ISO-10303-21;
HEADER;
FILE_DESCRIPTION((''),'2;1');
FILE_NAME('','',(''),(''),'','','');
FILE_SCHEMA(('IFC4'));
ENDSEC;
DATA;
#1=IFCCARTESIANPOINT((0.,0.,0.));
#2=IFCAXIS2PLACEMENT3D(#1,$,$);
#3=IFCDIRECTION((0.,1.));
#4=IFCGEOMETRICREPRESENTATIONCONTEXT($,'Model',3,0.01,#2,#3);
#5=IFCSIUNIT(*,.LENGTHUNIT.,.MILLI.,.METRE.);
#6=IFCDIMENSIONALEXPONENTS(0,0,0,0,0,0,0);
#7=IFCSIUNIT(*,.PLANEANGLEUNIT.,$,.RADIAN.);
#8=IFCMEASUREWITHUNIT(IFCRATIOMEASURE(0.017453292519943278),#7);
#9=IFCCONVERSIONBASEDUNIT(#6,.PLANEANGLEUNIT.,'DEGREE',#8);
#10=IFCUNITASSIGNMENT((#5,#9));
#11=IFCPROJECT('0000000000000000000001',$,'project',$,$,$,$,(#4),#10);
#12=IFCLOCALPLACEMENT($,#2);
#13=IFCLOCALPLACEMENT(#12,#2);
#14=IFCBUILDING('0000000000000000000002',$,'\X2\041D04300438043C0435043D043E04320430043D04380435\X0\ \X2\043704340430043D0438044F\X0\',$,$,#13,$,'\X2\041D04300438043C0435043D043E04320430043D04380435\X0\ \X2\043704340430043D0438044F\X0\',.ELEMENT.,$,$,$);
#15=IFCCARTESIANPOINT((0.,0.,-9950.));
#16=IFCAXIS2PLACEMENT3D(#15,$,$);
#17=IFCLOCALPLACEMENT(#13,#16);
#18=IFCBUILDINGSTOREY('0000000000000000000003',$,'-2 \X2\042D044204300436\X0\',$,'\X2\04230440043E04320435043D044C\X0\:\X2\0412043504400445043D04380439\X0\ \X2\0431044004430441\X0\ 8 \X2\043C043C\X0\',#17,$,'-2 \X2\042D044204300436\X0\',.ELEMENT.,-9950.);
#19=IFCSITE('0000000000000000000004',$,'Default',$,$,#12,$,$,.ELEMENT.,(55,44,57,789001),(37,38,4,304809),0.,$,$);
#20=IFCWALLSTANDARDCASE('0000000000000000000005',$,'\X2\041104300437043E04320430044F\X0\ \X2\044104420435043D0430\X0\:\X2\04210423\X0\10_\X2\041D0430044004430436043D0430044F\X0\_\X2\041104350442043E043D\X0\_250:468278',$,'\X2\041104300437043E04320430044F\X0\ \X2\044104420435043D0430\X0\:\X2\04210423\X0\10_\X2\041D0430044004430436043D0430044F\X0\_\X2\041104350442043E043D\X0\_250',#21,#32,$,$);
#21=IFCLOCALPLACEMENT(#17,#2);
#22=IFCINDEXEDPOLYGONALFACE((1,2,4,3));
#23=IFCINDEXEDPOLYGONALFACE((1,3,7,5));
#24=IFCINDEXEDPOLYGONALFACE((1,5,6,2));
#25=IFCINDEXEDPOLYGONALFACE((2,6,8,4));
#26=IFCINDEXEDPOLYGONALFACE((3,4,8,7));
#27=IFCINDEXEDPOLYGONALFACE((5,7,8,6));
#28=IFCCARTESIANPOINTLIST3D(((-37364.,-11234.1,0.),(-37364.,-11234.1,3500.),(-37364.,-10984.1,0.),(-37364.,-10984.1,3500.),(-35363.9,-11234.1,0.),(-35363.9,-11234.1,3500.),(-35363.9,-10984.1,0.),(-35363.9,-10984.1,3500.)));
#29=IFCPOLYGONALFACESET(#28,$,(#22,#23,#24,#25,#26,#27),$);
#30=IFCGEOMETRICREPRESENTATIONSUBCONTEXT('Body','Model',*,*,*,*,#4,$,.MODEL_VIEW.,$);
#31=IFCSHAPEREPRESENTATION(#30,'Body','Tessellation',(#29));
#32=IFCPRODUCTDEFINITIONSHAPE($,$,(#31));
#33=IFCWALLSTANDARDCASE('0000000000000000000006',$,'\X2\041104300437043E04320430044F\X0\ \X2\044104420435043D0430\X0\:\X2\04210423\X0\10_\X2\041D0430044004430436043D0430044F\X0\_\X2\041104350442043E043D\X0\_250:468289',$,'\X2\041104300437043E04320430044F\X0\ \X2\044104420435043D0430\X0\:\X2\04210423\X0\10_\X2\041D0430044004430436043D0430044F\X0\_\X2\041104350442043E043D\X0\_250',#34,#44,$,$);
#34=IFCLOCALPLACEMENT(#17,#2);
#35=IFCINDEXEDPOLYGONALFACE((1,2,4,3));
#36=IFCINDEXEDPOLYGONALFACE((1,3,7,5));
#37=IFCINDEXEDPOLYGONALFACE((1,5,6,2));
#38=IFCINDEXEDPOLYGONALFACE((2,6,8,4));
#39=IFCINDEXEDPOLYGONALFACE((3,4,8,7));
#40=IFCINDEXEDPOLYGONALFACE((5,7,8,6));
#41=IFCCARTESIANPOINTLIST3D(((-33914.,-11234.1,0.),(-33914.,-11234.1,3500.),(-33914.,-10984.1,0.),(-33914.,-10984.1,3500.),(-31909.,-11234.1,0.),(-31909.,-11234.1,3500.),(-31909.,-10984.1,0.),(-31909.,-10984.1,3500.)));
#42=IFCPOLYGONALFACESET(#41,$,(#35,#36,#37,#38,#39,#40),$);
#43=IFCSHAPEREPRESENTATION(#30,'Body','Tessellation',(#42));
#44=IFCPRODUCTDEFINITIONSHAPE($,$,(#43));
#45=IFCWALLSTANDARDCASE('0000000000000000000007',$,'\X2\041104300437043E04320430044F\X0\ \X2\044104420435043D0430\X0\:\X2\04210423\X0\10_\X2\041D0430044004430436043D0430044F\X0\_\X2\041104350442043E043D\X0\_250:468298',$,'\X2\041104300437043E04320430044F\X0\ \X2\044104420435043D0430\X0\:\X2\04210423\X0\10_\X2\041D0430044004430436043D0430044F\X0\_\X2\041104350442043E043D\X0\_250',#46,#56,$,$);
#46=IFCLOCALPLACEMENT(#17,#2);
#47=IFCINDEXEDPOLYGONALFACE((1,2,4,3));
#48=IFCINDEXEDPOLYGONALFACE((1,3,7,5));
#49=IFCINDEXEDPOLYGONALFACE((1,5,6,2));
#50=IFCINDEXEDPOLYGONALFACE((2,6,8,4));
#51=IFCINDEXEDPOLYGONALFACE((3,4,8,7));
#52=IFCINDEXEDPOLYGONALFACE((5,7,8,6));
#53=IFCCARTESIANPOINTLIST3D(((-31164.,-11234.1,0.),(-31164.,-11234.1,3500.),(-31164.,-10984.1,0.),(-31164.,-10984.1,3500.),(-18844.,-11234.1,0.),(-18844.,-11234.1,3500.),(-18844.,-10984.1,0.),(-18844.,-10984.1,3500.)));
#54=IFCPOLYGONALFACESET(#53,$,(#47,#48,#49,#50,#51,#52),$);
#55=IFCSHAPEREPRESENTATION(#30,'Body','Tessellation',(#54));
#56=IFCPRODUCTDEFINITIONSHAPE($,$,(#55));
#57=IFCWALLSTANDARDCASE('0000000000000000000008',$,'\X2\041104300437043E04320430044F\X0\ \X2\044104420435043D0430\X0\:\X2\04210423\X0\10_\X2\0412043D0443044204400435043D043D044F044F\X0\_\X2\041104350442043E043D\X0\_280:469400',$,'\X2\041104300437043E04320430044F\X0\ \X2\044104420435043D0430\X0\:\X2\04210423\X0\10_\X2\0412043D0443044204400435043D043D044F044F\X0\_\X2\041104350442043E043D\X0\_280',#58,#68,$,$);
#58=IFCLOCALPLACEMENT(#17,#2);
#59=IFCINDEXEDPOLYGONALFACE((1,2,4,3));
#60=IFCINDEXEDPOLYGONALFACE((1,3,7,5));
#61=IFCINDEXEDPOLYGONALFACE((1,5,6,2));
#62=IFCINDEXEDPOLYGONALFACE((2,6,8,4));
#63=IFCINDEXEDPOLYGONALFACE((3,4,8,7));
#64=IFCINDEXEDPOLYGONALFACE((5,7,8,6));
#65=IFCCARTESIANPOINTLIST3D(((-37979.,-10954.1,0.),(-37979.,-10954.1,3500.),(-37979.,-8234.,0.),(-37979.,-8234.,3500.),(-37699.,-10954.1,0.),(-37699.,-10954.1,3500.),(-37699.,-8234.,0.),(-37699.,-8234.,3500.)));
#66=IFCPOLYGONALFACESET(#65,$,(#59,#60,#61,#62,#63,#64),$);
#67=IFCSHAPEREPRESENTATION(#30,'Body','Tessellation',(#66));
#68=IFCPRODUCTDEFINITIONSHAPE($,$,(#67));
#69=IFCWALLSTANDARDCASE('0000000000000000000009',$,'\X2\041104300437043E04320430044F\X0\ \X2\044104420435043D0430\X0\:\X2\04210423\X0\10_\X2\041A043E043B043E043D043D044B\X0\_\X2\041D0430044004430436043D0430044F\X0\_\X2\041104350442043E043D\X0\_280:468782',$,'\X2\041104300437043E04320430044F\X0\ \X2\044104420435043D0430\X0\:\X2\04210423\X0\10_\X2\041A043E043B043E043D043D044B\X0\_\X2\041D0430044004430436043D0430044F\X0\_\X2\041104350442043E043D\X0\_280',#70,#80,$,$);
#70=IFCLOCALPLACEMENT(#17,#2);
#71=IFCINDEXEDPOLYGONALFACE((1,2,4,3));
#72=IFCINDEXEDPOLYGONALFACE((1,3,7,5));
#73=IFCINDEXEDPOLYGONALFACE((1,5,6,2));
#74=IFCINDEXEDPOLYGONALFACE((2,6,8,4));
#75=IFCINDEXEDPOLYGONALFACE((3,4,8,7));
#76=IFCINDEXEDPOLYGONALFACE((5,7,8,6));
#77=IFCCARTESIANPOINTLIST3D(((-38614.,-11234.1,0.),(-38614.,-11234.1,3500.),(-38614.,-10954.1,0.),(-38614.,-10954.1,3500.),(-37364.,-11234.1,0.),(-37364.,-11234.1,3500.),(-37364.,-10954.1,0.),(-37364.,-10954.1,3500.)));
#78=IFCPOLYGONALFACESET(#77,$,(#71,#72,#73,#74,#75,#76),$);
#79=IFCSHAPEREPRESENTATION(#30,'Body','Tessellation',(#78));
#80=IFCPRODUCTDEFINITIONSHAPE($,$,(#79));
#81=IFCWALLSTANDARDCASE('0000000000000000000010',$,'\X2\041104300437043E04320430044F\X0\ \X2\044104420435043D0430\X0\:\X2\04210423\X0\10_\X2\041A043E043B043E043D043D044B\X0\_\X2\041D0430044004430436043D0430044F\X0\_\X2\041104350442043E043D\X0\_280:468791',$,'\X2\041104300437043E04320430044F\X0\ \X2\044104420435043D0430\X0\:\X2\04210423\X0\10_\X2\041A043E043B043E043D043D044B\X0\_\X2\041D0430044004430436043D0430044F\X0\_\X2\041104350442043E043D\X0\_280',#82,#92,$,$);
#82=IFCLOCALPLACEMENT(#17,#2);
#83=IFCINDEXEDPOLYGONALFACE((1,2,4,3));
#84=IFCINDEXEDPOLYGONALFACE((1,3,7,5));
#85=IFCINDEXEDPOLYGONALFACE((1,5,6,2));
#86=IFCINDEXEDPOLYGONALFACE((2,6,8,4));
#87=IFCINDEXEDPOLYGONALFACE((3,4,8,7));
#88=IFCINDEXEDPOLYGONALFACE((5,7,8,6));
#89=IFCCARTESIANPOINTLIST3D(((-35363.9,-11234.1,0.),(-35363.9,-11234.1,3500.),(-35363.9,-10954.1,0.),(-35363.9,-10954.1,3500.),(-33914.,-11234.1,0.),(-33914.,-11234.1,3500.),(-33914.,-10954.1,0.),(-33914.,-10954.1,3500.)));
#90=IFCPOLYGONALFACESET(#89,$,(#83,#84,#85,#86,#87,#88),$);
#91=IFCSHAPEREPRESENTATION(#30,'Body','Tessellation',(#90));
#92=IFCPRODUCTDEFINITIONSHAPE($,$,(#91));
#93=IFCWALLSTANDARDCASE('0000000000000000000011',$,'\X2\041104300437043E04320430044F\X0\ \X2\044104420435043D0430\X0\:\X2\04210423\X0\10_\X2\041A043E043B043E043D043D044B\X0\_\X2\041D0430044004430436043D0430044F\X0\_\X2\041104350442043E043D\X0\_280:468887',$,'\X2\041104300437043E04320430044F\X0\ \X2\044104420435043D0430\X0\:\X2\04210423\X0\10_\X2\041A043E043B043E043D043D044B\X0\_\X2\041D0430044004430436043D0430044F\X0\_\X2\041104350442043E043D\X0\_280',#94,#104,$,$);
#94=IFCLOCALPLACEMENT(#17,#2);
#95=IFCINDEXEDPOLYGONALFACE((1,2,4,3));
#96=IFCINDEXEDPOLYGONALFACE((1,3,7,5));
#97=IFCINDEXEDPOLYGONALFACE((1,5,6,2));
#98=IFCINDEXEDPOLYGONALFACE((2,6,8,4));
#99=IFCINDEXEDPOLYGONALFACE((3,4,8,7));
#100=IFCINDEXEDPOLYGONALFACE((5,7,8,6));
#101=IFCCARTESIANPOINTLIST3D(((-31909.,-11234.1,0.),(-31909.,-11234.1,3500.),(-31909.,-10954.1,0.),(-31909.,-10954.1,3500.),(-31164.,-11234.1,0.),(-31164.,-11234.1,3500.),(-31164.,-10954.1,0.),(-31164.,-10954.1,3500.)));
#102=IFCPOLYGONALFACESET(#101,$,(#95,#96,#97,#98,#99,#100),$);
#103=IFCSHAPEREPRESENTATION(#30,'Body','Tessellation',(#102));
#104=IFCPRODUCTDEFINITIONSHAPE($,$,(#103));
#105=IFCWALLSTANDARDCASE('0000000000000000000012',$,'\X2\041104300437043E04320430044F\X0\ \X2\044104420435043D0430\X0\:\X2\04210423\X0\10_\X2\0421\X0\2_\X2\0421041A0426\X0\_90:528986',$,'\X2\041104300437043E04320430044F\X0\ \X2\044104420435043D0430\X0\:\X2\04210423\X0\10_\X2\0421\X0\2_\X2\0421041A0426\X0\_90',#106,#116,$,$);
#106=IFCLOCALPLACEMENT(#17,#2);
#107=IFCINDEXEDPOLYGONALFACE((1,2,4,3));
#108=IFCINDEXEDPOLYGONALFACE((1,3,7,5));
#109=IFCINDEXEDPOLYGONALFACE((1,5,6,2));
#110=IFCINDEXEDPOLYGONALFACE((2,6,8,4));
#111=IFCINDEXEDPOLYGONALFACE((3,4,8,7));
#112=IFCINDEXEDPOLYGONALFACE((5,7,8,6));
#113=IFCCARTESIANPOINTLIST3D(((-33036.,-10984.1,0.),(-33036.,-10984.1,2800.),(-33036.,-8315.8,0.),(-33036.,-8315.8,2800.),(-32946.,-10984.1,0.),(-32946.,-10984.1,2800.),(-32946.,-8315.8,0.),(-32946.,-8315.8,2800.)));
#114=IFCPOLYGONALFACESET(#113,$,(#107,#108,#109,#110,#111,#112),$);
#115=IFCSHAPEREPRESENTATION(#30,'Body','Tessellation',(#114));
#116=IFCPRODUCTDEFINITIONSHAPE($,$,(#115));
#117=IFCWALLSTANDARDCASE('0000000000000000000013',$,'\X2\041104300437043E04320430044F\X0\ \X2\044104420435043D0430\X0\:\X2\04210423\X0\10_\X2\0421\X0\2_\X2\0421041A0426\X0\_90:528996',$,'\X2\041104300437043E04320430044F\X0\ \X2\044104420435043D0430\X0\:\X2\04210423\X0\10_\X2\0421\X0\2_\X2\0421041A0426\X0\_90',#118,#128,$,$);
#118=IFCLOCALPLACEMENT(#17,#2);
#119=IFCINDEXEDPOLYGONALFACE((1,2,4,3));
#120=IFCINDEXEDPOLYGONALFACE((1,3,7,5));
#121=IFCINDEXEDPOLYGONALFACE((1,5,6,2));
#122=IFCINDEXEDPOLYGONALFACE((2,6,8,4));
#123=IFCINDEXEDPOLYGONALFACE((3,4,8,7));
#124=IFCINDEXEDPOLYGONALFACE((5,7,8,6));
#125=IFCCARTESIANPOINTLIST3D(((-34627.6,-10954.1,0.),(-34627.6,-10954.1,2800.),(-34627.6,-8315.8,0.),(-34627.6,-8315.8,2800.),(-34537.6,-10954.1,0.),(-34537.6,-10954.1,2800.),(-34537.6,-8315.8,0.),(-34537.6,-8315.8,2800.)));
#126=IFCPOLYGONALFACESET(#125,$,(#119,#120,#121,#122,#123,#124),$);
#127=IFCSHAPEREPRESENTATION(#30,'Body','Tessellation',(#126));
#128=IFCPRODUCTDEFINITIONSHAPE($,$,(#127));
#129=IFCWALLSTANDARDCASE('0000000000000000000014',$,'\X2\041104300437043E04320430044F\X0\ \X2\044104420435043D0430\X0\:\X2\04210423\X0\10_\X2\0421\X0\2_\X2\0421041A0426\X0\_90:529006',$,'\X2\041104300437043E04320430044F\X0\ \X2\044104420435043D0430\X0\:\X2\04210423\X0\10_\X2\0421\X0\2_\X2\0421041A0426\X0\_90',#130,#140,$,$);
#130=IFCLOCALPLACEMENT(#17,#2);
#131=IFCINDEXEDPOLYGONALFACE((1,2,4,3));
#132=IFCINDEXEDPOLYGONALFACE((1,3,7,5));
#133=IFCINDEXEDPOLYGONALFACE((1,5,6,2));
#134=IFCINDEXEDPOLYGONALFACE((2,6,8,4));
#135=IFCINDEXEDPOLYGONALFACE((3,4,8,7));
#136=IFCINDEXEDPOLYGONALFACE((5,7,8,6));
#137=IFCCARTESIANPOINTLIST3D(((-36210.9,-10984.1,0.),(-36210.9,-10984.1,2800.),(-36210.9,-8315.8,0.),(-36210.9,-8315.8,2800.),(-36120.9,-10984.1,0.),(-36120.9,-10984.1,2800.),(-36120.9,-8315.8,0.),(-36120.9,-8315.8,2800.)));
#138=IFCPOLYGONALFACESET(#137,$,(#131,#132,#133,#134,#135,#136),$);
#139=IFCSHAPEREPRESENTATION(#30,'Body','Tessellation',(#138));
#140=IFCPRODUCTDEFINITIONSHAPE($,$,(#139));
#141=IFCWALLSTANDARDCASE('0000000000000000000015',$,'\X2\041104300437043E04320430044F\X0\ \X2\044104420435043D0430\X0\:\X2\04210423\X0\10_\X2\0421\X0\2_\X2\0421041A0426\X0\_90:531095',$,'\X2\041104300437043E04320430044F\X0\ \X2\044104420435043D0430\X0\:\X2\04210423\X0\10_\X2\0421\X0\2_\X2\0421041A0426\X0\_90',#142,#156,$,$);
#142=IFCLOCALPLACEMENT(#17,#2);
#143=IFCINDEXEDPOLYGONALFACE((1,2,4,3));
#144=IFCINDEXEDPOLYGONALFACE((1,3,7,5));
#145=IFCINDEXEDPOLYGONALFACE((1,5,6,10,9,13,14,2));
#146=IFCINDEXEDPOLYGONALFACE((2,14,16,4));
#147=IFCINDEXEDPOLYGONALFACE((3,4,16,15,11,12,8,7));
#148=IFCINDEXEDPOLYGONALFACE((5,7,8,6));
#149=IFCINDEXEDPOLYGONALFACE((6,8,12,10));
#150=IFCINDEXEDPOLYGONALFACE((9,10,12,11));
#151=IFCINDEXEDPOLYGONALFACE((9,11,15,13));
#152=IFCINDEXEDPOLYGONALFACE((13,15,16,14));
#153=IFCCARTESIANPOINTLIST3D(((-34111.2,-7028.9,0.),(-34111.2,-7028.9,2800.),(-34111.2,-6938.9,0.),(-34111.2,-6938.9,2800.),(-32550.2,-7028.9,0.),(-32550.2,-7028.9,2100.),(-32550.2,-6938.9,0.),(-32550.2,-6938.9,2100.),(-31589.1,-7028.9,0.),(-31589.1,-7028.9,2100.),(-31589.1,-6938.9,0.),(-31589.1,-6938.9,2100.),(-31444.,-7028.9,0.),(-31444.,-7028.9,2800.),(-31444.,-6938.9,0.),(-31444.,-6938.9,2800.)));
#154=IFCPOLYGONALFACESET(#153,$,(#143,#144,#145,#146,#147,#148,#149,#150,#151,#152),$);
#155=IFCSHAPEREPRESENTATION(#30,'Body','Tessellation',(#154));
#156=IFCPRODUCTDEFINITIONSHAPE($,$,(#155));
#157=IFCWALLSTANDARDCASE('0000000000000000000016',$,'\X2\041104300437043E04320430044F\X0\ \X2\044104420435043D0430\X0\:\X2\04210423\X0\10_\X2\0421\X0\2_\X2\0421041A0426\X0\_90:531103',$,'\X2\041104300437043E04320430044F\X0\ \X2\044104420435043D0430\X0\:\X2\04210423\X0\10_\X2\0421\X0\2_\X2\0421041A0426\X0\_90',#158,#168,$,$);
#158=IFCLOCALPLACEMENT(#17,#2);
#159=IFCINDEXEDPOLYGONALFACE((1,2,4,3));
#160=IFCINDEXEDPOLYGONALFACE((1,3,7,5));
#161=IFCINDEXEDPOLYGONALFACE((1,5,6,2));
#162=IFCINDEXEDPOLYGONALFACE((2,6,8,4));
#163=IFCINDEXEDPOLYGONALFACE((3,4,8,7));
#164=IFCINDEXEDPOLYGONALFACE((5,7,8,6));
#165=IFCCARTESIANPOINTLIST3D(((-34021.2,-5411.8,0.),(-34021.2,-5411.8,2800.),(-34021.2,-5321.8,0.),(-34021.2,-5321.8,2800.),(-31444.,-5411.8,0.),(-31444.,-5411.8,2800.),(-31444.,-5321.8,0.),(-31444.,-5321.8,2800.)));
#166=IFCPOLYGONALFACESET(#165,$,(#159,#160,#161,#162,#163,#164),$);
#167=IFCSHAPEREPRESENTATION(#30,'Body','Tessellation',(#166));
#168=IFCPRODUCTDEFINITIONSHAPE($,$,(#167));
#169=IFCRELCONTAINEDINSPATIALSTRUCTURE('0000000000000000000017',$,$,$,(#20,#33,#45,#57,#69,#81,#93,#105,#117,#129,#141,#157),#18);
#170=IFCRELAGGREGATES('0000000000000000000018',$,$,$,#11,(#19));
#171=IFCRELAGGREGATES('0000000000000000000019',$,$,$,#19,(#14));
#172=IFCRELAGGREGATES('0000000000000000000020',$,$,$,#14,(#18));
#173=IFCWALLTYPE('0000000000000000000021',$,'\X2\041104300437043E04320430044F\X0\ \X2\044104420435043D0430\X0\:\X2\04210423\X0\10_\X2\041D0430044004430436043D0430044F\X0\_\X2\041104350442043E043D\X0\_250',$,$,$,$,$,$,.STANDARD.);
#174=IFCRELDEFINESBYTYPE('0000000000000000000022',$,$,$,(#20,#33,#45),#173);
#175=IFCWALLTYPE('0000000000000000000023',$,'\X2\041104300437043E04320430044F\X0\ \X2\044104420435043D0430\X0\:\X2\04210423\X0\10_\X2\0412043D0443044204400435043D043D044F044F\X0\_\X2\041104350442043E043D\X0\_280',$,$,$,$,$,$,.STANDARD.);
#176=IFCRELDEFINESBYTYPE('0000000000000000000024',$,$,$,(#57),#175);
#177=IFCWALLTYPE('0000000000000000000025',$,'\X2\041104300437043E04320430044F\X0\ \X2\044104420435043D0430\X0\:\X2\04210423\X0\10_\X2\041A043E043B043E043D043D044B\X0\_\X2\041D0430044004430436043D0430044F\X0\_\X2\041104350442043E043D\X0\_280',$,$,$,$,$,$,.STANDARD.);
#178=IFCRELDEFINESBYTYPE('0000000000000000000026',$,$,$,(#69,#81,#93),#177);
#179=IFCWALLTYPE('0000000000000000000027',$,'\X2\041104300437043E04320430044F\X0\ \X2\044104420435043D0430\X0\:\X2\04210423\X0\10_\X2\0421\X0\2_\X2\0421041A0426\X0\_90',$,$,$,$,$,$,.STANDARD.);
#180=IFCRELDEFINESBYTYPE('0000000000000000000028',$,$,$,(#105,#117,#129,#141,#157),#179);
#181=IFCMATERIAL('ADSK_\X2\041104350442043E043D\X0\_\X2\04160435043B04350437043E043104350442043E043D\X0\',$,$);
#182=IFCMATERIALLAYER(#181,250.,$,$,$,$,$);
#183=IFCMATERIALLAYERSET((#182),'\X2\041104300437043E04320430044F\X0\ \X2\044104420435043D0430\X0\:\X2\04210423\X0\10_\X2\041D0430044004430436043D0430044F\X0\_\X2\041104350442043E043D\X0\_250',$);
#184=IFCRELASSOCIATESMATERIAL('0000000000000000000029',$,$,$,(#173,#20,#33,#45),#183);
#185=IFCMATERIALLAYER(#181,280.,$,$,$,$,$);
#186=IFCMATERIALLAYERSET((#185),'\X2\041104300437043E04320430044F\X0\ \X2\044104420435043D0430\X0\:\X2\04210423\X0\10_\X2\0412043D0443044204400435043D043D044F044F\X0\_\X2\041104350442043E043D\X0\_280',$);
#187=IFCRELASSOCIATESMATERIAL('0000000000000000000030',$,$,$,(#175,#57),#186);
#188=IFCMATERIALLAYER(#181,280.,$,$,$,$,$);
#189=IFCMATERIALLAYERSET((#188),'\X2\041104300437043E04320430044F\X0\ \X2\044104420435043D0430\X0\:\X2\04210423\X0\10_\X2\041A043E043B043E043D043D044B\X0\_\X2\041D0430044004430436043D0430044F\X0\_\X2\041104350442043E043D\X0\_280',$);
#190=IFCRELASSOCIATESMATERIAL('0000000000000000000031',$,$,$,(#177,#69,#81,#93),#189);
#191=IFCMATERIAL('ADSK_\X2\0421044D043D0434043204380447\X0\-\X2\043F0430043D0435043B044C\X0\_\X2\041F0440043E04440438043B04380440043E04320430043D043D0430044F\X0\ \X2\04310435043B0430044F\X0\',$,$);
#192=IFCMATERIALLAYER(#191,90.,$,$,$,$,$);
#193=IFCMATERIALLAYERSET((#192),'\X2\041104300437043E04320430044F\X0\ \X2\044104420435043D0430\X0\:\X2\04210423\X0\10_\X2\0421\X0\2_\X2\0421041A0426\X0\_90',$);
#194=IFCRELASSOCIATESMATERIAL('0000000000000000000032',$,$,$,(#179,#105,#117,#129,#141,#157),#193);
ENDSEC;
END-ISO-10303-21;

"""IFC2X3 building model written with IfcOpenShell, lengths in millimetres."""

from ifc_helpers import new_model, entity, si_unit, converted_unit, direction, frame, frame_2d, origin, place, context, subcontext, project, spatial, rectangle, extrude, material, layer, layer_set, layer_usage, type_object, element, save


model = new_model("IFC2X3")

# Units and contexts
model_context = context("Model", 3, precision=0.01, world=origin(), true_north=direction((0.0, 1.0)))
body_context = subcontext(model_context, "Body", "Model", "MODEL_VIEW")
ifc_project = project(units=[si_unit("LENGTHUNIT", "METRE", prefix="MILLI"), converted_unit("PLANEANGLEUNIT", "DEGREE", entity("IfcRatioMeasure", 0.017453292519943278), si_unit("PLANEANGLEUNIT", "RADIAN"), dimensions=[0, 0, 0, 0, 0, 0, 0])], contexts=[model_context])

# Site, building, storey
site_placement = place(None, origin())
site = spatial("IfcSite", under=ifc_project, at=site_placement, Name="Default", CompositionType="ELEMENT", RefLatitude=(55, 44, 57, 789001), RefLongitude=(37, 38, 4, 304809), RefElevation=0.0)
building_placement = place(site_placement, origin())
building = spatial("IfcBuilding", under=site, at=building_placement, Name="Наименование здания", LongName="Наименование здания", CompositionType="ELEMENT")
storey_placement = place(building_placement, frame((0.0, 0.0, -9950.0)))
storey = spatial("IfcBuildingStorey", under=building, at=storey_placement, Name="-2 Этаж", ObjectType="Уровень:Верхний брус 8 мм", LongName="-2 Этаж", CompositionType="ELEMENT", Elevation=-9950.0)

# Shared definitions
ifc_material_1 = material(Name="ADSK_Бетон_Железобетон")

# Walls
ifc_layer_1 = layer(ifc_material_1, 250.0)
ifc_layer_set_1 = layer_set([ifc_layer_1], Name="Базовая стена:СУ10_Наружная_Бетон_250")
ifc_layer_usage_1 = layer_usage(ifc_layer_set_1, "AXIS2", "NEGATIVE", 125.0)
wall_type_1 = type_object("IfcWallType", Name="Базовая стена:СУ10_Наружная_Бетон_250", PredefinedType="STANDARD", material=ifc_layer_set_1)
wall_1_placement = place(storey_placement, frame((-37364.0, -11109.1, 0.0)))
element("IfcWallStandardCase", 1, at=wall_1_placement, inside=storey, type_object=wall_type_1, material=ifc_layer_usage_1, Name="Базовая стена:СУ10_Наружная_Бетон_250:468278", ObjectType="Базовая стена:СУ10_Наружная_Бетон_250", context=body_context, shape_type="SweptSolid", body=[
    extrude(rectangle(XDim=2000.1, YDim=250.0, at=frame_2d((1000.0, 0.0), x_axis=(-1.0, 0.0))), origin(), (0.0, 0.0, 1.0), 3500.0),
])
wall_2_placement = place(storey_placement, frame((-33914.0, -11109.1, 0.0)))
element("IfcWallStandardCase", 2, at=wall_2_placement, inside=storey, type_object=wall_type_1, material=ifc_layer_usage_1, Name="Базовая стена:СУ10_Наружная_Бетон_250:468289", ObjectType="Базовая стена:СУ10_Наружная_Бетон_250", context=body_context, shape_type="SweptSolid", body=[
    extrude(rectangle(XDim=2005.0, YDim=250.0, at=frame_2d((1002.5, 0.0), x_axis=(-1.0, 0.0))), origin(), (0.0, 0.0, 1.0), 3500.0),
])
wall_3_placement = place(storey_placement, frame((-31164.0, -11109.1, 0.0)))
element("IfcWallStandardCase", 3, at=wall_3_placement, inside=storey, type_object=wall_type_1, material=ifc_layer_usage_1, Name="Базовая стена:СУ10_Наружная_Бетон_250:468298", ObjectType="Базовая стена:СУ10_Наружная_Бетон_250", context=body_context, shape_type="SweptSolid", body=[
    extrude(rectangle(XDim=12320.0, YDim=250.0, at=frame_2d((6160.0, 0.0), x_axis=(-1.0, 0.0))), origin(), (0.0, 0.0, 1.0), 3500.0),
])
ifc_layer_2 = layer(ifc_material_1, 280.0)
ifc_layer_set_2 = layer_set([ifc_layer_2], Name="Базовая стена:СУ10_Внутренняя_Бетон_280")
ifc_layer_usage_2 = layer_usage(ifc_layer_set_2, "AXIS2", "NEGATIVE", 140.0)
wall_type_2 = type_object("IfcWallType", Name="Базовая стена:СУ10_Внутренняя_Бетон_280", PredefinedType="STANDARD", material=ifc_layer_set_2)
wall_4_placement = place(storey_placement, frame((-37839.0, -8234.0, 0.0), z_axis=(0.0, 0.0, 1.0), x_axis=(0.0, -1.0, 0.0)))
element("IfcWallStandardCase", 4, at=wall_4_placement, inside=storey, type_object=wall_type_2, material=ifc_layer_usage_2, Name="Базовая стена:СУ10_Внутренняя_Бетон_280:469400", ObjectType="Базовая стена:СУ10_Внутренняя_Бетон_280", context=body_context, shape_type="SweptSolid", body=[
    extrude(rectangle(XDim=2720.1, YDim=280.0, at=frame_2d((1360.0, 0.0), x_axis=(-1.0, 0.0))), origin(), (0.0, 0.0, 1.0), 3500.0),
])
ifc_layer_3 = layer(ifc_material_1, 280.0)
ifc_layer_set_3 = layer_set([ifc_layer_3], Name="Базовая стена:СУ10_Колонны_Наружная_Бетон_280")
ifc_layer_usage_3 = layer_usage(ifc_layer_set_3, "AXIS2", "NEGATIVE", 140.0)
wall_type_3 = type_object("IfcWallType", Name="Базовая стена:СУ10_Колонны_Наружная_Бетон_280", PredefinedType="STANDARD", material=ifc_layer_set_3)
wall_5_placement = place(storey_placement, frame((-38614.0, -11094.1, 0.0)))
element("IfcWallStandardCase", 5, at=wall_5_placement, inside=storey, type_object=wall_type_3, material=ifc_layer_usage_3, Name="Базовая стена:СУ10_Колонны_Наружная_Бетон_280:468782", ObjectType="Базовая стена:СУ10_Колонны_Наружная_Бетон_280", context=body_context, shape_type="SweptSolid", body=[
    extrude(rectangle(XDim=1250.0, YDim=280.0, at=frame_2d((625.0, 0.0), x_axis=(-1.0, 0.0))), origin(), (0.0, 0.0, 1.0), 3500.0),
])
wall_6_placement = place(storey_placement, frame((-35363.9, -11094.1, 0.0)))
element("IfcWallStandardCase", 6, at=wall_6_placement, inside=storey, type_object=wall_type_3, material=ifc_layer_usage_3, Name="Базовая стена:СУ10_Колонны_Наружная_Бетон_280:468791", ObjectType="Базовая стена:СУ10_Колонны_Наружная_Бетон_280", context=body_context, shape_type="SweptSolid", body=[
    extrude(rectangle(XDim=1450.0, YDim=280.0, at=frame_2d((725.0, 0.0), x_axis=(-1.0, 0.0))), origin(), (0.0, 0.0, 1.0), 3500.0),
])
wall_7_placement = place(storey_placement, frame((-31909.0, -11094.1, 0.0)))
element("IfcWallStandardCase", 7, at=wall_7_placement, inside=storey, type_object=wall_type_3, material=ifc_layer_usage_3, Name="Базовая стена:СУ10_Колонны_Наружная_Бетон_280:468887", ObjectType="Базовая стена:СУ10_Колонны_Наружная_Бетон_280", context=body_context, shape_type="SweptSolid", body=[
    extrude(rectangle(XDim=745.0, YDim=280.0, at=frame_2d((372.5, 0.0), x_axis=(-1.0, 0.0))), origin(), (0.0, 0.0, 1.0), 3500.0),
])
ifc_material_2 = material(Name="ADSK_Сэндвич-панель_Профилированная белая")
ifc_layer_4 = layer(ifc_material_2, 90.0)
ifc_layer_set_4 = layer_set([ifc_layer_4], Name="Базовая стена:СУ10_С2_СКЦ_90")
ifc_layer_usage_4 = layer_usage(ifc_layer_set_4, "AXIS2", "NEGATIVE", 45.0)
wall_type_4 = type_object("IfcWallType", Name="Базовая стена:СУ10_С2_СКЦ_90", PredefinedType="STANDARD", material=ifc_layer_set_4)
wall_8_placement = place(storey_placement, frame((-32991.0, -8315.8, 0.0), z_axis=(0.0, 0.0, 1.0), x_axis=(0.0, -1.0, 0.0)))
element("IfcWallStandardCase", 8, at=wall_8_placement, inside=storey, type_object=wall_type_4, material=ifc_layer_usage_4, Name="Базовая стена:СУ10_С2_СКЦ_90:528986", ObjectType="Базовая стена:СУ10_С2_СКЦ_90", context=body_context, shape_type="SweptSolid", body=[
    extrude(rectangle(XDim=2668.3, YDim=90.0, at=frame_2d((1334.1, 0.0), x_axis=(-1.0, 0.0))), origin(), (0.0, 0.0, 1.0), 2800.0),
])
wall_9_placement = place(storey_placement, frame((-34582.6, -8315.8, 0.0), z_axis=(0.0, 0.0, 1.0), x_axis=(0.0, -1.0, 0.0)))
element("IfcWallStandardCase", 9, at=wall_9_placement, inside=storey, type_object=wall_type_4, material=ifc_layer_usage_4, Name="Базовая стена:СУ10_С2_СКЦ_90:528996", ObjectType="Базовая стена:СУ10_С2_СКЦ_90", context=body_context, shape_type="SweptSolid", body=[
    extrude(rectangle(XDim=2638.3, YDim=90.0, at=frame_2d((1319.1, 0.0), x_axis=(-1.0, 0.0))), origin(), (0.0, 0.0, 1.0), 2800.0),
])
wall_10_placement = place(storey_placement, frame((-36165.9, -8315.8, 0.0), z_axis=(0.0, 0.0, 1.0), x_axis=(0.0, -1.0, 0.0)))
element("IfcWallStandardCase", 10, at=wall_10_placement, inside=storey, type_object=wall_type_4, material=ifc_layer_usage_4, Name="Базовая стена:СУ10_С2_СКЦ_90:529006", ObjectType="Базовая стена:СУ10_С2_СКЦ_90", context=body_context, shape_type="SweptSolid", body=[
    extrude(rectangle(XDim=2668.3, YDim=90.0, at=frame_2d((1334.1, 0.0), x_axis=(-1.0, 0.0))), origin(), (0.0, 0.0, 1.0), 2800.0),
])

# Wall, opening
wall_11_placement = place(storey_placement, frame((-31444.0, -6983.9, 0.0), z_axis=(0.0, 0.0, 1.0), x_axis=(-1.0, 0.0, 0.0)))
wall_11 = element("IfcWallStandardCase", 11, at=wall_11_placement, inside=storey, type_object=wall_type_4, material=ifc_layer_usage_4, Name="Базовая стена:СУ10_С2_СКЦ_90:531095", ObjectType="Базовая стена:СУ10_С2_СКЦ_90", context=body_context, shape_type="SweptSolid", body=[
    extrude(rectangle(XDim=2667.2, YDim=90.0, at=frame_2d((1333.6, 0.0), x_axis=(1.0, 0.0))), origin(), (0.0, 0.0, 1.0), 2800.0),
])
opening_1_placement = place(wall_11_placement, origin())
element("IfcOpeningElement", 12, at=opening_1_placement, cuts=wall_11, ObjectType="Opening", context=body_context, shape_type="SweptSolid", body=[
    extrude(rectangle(XDim=2100.0, YDim=961.1, at=frame_2d((0.0, 0.0), x_axis=(1.0, 0.0))), frame((625.7, -45.0, 1050.0), z_axis=(0.0, 1.0, 0.0), x_axis=(0.0, 0.0, -1.0)), (0.0, 0.0, 1.0), 90.0),
])

# Wall
wall_12_placement = place(storey_placement, frame((-31444.0, -5366.8, 0.0), z_axis=(0.0, 0.0, 1.0), x_axis=(-1.0, 0.0, 0.0)))
element("IfcWallStandardCase", 13, at=wall_12_placement, inside=storey, type_object=wall_type_4, material=ifc_layer_usage_4, Name="Базовая стена:СУ10_С2_СКЦ_90:531103", ObjectType="Базовая стена:СУ10_С2_СКЦ_90", context=body_context, shape_type="SweptSolid", body=[
    extrude(rectangle(XDim=2577.2, YDim=90.0, at=frame_2d((1288.6, 0.0), x_axis=(-1.0, 0.0))), origin(), (0.0, 0.0, 1.0), 2800.0),
])

save(model, "model.ifc")
